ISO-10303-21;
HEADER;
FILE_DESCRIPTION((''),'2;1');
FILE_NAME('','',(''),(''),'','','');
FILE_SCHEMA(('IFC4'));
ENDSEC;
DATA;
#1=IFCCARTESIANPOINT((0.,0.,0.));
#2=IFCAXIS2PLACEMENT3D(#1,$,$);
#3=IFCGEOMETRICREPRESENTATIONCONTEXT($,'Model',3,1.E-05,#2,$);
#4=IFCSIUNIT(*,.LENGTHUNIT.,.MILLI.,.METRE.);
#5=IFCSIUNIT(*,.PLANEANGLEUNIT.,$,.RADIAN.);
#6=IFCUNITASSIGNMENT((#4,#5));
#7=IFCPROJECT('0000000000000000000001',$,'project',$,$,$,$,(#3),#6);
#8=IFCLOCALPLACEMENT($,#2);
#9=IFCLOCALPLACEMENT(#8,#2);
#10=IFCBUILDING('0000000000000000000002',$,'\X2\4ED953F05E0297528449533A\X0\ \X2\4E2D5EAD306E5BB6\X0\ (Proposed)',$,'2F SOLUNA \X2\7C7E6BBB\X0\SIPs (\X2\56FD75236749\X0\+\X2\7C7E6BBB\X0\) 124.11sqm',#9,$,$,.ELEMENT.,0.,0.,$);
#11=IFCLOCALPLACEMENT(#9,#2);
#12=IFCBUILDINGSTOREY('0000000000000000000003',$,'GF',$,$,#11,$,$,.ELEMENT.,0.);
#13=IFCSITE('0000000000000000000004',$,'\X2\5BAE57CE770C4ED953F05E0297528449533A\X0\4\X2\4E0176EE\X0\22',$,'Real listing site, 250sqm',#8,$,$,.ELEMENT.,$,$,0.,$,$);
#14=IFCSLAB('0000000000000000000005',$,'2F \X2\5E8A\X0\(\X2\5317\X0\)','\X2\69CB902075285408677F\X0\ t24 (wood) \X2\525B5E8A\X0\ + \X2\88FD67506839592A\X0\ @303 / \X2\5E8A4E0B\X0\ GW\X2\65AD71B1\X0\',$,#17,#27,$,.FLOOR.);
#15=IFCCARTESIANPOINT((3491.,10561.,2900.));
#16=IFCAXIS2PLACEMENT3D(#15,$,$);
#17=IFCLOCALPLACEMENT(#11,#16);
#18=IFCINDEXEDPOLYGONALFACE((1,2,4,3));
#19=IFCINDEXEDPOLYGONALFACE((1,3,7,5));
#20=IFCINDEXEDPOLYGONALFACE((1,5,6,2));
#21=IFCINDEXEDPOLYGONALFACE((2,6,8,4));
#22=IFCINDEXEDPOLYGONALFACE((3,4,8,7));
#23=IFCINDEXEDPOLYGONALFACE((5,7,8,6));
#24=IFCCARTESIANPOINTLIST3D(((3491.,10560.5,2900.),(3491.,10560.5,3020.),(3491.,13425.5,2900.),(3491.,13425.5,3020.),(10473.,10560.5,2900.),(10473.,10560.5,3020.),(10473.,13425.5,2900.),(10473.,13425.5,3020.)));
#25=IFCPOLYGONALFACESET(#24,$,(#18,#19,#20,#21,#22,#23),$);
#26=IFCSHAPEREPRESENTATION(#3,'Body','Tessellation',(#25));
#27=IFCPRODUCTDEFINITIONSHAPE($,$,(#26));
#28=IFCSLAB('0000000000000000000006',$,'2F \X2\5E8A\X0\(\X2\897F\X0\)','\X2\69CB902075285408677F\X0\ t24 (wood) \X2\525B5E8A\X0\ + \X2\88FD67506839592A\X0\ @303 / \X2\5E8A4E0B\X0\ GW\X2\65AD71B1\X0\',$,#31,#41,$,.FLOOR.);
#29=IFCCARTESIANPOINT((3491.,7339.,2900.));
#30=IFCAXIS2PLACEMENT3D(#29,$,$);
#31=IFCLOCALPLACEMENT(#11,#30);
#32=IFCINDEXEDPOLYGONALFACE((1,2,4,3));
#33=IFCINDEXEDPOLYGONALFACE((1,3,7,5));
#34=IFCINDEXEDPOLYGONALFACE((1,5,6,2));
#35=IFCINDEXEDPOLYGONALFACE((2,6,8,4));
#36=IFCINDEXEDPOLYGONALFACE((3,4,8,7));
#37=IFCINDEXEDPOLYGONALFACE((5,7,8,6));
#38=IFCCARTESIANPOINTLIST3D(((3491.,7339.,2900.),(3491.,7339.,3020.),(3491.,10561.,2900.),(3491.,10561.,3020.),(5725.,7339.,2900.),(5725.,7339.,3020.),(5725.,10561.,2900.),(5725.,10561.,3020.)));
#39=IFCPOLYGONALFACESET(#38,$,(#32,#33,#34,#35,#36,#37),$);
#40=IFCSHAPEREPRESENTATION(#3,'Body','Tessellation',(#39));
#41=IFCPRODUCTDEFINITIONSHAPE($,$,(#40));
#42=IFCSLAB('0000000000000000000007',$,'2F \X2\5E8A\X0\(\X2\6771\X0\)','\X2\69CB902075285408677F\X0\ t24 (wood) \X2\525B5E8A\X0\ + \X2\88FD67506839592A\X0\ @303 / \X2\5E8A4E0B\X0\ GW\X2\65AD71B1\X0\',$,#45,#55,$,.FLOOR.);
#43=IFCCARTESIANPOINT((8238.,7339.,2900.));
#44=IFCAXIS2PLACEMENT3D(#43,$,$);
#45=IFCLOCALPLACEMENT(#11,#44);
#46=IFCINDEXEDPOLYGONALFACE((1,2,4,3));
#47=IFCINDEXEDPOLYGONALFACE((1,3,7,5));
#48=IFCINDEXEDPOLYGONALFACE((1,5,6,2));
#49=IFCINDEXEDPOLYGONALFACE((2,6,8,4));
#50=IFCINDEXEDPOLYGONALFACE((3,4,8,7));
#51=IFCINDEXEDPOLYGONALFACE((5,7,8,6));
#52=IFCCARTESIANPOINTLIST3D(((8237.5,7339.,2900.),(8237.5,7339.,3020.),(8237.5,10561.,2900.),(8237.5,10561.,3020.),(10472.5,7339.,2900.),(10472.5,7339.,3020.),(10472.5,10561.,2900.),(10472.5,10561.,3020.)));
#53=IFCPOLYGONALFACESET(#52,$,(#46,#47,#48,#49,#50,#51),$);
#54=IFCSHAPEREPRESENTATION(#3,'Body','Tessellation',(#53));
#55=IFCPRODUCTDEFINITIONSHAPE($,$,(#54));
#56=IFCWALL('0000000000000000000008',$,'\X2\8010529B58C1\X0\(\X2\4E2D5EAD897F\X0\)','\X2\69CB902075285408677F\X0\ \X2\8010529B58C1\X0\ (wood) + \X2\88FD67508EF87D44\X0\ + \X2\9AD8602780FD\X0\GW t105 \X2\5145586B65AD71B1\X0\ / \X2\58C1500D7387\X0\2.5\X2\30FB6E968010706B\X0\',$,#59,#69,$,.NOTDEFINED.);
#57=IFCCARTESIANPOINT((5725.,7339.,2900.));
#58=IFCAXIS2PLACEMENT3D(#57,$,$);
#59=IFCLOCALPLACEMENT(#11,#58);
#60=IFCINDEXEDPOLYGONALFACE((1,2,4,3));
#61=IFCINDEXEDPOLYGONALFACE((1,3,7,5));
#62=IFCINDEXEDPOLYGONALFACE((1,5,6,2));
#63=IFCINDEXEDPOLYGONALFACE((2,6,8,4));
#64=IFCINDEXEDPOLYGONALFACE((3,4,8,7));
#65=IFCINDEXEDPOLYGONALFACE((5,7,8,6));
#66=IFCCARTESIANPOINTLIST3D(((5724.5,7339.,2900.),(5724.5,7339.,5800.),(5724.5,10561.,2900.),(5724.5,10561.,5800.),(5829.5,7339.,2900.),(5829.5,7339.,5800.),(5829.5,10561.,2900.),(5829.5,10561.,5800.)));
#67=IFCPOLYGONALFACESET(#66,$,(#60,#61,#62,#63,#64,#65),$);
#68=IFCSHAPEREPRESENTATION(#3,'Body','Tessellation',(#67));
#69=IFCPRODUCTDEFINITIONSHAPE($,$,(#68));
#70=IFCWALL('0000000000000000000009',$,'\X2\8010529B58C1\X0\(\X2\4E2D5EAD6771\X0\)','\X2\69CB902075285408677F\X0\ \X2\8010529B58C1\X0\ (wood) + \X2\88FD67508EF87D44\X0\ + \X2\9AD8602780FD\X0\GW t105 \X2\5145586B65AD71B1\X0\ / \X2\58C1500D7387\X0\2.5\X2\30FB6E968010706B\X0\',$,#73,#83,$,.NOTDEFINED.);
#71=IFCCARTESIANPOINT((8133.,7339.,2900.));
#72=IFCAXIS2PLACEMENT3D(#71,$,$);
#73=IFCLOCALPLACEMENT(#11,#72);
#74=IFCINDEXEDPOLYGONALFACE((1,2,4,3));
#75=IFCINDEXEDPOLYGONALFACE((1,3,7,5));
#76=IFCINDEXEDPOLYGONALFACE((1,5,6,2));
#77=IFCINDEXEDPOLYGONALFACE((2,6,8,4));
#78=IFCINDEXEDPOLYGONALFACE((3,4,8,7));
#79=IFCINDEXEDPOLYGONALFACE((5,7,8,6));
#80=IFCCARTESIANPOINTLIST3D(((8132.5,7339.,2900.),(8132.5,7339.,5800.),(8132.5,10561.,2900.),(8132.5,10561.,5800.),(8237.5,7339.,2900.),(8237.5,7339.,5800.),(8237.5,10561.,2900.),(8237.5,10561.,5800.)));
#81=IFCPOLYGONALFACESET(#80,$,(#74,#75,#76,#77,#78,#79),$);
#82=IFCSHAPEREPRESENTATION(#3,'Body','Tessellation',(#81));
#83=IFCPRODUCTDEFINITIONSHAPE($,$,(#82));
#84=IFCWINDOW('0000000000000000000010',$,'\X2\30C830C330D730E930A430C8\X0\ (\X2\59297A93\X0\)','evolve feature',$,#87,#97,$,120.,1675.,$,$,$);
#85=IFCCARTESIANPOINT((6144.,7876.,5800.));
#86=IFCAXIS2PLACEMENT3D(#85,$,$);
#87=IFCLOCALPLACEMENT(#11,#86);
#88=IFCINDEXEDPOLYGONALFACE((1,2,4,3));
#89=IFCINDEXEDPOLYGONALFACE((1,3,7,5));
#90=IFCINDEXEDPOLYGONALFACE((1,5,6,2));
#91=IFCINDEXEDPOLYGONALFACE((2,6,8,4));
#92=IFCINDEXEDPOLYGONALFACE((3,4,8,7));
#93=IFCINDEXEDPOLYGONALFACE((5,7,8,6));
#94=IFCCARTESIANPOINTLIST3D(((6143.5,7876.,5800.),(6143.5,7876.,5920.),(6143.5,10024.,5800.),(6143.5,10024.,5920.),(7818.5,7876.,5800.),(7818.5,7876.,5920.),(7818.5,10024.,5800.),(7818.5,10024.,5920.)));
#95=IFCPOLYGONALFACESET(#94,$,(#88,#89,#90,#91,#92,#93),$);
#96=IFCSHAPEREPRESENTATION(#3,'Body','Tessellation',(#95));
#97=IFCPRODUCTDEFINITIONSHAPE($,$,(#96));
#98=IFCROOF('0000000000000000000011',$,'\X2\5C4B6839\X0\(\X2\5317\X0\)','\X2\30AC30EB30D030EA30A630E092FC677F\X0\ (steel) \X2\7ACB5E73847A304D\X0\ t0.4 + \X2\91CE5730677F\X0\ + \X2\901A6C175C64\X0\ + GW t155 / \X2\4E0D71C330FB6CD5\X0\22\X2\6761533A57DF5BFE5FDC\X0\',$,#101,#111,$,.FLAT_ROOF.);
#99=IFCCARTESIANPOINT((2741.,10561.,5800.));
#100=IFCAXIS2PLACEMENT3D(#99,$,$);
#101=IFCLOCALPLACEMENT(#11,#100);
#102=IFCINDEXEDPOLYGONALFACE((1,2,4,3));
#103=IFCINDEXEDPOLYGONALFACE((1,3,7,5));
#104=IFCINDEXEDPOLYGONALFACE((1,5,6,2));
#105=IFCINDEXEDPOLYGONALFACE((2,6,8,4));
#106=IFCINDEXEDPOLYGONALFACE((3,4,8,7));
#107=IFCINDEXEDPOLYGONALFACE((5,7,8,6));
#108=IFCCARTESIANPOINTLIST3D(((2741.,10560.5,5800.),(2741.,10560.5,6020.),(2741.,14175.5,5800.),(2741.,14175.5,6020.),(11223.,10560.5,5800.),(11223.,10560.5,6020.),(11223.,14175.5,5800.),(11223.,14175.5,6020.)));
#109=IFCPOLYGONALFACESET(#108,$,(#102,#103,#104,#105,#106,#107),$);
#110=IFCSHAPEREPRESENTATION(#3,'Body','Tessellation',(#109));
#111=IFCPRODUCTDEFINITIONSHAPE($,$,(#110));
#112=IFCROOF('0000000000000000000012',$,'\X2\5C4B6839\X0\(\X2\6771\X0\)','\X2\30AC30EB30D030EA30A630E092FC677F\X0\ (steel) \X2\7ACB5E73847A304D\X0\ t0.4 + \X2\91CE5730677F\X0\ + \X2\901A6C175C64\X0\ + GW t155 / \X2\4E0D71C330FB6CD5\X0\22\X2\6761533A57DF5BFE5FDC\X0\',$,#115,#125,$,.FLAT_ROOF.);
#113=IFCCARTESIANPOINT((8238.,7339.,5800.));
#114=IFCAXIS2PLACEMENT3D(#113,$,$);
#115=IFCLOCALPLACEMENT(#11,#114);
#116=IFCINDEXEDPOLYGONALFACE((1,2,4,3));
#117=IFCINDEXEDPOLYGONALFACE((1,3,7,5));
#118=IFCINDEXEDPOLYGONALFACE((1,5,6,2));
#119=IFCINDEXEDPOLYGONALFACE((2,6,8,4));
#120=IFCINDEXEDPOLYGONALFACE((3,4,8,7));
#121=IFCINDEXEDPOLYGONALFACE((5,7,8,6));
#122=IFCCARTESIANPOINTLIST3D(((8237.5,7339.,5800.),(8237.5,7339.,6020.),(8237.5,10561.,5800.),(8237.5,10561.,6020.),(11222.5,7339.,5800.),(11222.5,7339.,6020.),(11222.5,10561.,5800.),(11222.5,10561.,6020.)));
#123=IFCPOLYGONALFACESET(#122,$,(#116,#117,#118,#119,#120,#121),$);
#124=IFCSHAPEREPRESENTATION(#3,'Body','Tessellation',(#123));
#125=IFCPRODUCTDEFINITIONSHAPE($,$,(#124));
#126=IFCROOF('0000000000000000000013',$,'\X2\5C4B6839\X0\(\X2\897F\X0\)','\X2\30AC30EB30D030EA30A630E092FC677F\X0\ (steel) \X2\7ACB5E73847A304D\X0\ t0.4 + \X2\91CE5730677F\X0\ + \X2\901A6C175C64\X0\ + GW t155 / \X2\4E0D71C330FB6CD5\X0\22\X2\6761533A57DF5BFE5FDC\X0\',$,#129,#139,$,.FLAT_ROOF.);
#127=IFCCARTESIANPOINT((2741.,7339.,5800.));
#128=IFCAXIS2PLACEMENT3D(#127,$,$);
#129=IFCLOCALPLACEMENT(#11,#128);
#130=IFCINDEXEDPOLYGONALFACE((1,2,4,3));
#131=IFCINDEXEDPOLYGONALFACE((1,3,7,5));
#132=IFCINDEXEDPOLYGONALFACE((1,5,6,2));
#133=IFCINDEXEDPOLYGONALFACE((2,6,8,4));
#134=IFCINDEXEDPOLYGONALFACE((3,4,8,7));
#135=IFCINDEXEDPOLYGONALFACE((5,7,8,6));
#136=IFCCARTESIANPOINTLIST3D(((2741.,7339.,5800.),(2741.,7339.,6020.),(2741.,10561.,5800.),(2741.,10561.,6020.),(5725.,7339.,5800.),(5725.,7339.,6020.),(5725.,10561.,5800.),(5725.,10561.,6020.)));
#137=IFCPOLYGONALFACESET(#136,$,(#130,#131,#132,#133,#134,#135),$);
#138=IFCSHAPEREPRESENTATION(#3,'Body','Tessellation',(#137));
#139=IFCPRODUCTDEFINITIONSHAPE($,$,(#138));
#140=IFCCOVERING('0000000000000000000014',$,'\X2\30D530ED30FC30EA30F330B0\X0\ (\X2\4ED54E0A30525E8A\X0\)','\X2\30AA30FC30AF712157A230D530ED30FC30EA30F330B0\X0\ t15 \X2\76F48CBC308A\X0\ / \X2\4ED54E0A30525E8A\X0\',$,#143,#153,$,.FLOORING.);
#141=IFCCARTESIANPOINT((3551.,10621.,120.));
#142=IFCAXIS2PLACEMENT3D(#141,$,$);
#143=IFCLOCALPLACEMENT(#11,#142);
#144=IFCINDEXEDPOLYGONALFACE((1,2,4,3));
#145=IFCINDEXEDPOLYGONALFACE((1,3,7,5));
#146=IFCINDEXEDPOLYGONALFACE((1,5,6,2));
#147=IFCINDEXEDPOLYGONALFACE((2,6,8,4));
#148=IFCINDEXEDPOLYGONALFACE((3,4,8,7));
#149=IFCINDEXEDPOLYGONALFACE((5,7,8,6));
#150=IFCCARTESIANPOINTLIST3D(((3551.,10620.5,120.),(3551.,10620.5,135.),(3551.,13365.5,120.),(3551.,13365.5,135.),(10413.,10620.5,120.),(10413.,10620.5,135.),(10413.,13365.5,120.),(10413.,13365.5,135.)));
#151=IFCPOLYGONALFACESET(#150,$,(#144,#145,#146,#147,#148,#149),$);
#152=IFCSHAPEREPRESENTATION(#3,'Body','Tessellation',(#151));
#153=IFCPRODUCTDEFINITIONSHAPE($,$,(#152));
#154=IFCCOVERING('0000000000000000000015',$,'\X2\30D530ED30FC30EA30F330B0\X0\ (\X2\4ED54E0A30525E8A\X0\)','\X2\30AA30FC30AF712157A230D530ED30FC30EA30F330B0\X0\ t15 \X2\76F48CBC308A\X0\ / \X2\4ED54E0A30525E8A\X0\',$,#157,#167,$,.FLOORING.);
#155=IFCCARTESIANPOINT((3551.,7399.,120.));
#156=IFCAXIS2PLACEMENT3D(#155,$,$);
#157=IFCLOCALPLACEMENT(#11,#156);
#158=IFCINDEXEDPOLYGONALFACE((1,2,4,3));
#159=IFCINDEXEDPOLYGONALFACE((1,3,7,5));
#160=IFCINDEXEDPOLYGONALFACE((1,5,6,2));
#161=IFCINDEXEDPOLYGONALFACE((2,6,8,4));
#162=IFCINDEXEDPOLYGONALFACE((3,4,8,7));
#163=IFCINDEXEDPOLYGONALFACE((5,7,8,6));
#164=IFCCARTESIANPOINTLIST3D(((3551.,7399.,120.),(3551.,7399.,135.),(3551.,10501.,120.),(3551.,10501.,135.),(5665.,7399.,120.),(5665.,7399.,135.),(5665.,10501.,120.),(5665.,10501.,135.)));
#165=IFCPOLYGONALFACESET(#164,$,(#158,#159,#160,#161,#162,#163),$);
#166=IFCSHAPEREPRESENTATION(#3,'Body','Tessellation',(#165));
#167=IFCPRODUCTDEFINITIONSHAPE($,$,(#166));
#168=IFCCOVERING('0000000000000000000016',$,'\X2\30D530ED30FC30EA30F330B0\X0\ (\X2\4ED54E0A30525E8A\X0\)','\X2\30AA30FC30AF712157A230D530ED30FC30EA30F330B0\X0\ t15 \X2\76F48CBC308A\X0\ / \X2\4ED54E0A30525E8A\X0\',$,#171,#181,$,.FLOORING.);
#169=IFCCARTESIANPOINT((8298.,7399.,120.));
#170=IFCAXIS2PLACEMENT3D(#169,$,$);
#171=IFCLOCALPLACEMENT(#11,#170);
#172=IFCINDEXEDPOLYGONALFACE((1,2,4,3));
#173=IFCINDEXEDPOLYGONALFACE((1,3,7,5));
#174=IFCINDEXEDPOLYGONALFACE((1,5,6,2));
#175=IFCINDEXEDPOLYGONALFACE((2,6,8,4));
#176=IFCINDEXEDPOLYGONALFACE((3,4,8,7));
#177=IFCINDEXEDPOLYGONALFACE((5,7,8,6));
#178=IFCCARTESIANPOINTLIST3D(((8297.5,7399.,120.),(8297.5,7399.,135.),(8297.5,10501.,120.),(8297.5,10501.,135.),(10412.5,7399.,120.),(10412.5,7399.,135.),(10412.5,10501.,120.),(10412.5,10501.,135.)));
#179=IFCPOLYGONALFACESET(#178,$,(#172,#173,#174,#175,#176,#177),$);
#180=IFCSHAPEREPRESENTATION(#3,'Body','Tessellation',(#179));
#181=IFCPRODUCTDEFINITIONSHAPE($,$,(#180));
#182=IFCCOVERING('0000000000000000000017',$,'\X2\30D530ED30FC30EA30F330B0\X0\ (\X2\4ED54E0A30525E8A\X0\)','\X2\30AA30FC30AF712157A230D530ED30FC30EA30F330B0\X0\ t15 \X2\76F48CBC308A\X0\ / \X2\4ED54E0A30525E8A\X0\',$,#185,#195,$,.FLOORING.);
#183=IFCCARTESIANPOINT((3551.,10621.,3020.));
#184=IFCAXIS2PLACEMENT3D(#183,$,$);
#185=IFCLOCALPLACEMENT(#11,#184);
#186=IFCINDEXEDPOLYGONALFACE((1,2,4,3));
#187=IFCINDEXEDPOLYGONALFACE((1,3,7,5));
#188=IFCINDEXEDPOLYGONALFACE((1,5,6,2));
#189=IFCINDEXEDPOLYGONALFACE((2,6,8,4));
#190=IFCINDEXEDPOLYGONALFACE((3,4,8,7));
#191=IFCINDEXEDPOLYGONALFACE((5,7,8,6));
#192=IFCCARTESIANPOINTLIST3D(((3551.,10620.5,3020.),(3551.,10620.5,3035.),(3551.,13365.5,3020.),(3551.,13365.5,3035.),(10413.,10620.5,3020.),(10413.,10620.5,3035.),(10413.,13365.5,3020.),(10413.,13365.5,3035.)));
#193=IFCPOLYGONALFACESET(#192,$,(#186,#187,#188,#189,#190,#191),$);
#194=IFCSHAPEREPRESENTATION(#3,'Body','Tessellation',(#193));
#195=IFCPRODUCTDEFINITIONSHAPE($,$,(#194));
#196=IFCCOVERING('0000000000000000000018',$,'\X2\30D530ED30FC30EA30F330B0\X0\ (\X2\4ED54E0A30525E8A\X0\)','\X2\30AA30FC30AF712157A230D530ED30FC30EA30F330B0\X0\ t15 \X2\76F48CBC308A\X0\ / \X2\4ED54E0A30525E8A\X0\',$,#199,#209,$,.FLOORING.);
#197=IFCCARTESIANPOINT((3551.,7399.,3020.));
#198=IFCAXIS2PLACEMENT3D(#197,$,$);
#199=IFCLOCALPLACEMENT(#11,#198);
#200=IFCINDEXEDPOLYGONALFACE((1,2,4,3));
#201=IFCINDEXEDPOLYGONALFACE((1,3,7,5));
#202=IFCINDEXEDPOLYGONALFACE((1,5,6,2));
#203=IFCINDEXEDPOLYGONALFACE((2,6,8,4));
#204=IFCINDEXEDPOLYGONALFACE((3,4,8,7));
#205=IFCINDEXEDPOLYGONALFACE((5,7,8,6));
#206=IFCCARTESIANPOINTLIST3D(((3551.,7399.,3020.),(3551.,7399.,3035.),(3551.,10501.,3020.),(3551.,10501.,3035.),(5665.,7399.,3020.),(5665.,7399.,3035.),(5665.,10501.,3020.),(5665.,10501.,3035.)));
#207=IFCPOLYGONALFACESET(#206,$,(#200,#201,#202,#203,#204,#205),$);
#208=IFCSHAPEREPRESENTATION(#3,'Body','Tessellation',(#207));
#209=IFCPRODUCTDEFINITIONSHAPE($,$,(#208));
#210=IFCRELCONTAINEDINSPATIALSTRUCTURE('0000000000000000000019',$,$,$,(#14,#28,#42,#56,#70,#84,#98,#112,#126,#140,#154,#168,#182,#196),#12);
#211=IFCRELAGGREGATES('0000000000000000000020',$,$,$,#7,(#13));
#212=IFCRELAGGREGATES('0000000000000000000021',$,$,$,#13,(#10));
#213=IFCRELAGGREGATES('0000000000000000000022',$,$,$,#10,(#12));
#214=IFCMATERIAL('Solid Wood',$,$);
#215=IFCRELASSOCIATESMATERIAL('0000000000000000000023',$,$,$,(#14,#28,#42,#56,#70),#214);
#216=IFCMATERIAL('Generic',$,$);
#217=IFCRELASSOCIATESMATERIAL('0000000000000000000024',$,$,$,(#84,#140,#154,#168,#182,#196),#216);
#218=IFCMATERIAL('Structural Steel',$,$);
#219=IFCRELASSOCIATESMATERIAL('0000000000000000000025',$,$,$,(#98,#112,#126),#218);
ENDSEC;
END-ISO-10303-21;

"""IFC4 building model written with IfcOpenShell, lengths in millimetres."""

from ifc_helpers import new_model, si_unit, frame, frame_2d, origin, place, context, project, spatial, rectangle, extrude, material, element, save


model = new_model("IFC4")

# Units and contexts
model_context = context("Model", 3, precision=1e-05, world=origin())
ifc_project = project(units=[si_unit("LENGTHUNIT", "METRE", prefix="MILLI"), si_unit("PLANEANGLEUNIT", "RADIAN")], contexts=[model_context])

# Site, building, storey
site_placement = place(None, origin())
site = spatial("IfcSite", under=ifc_project, at=site_placement, Name="宮城県仙台市青葉区4丁目22", ObjectType="Real listing site, 250sqm", CompositionType="ELEMENT", RefElevation=0.0)
building_placement = place(site_placement, origin())
building = spatial("IfcBuilding", under=site, at=building_placement, Name="仙台市青葉区 中庭の家 (Proposed)", ObjectType="2F SOLUNA 籾殻SIPs (国産杉+籾殻) 124.11sqm", CompositionType="ELEMENT", ElevationOfRefHeight=0.0, ElevationOfTerrain=0.0)
storey_placement = place(building_placement, origin())
storey = spatial("IfcBuildingStorey", under=building, at=storey_placement, Name="GF", CompositionType="ELEMENT", Elevation=0.0)

# Slabs
ifc_material_1 = material(Name="Solid Wood")
slab_1_placement = place(storey_placement, frame((3491.0, 10561.0, 2900.0)))
element("IfcSlab", 1, at=slab_1_placement, inside=storey, material=ifc_material_1, Name="2F 床(北)", Description="構造用合板 t24 (wood) 剛床 + 製材根太 @303 / 床下 GW断熱", PredefinedType="FLOOR", context=model_context, shape_type="SweptSolid", body=[
    extrude(rectangle(XDim=6982.0, YDim=2865.0, at=frame_2d((3491.0, 1432.0))), frame((3491.0, 10561.0, 2900.0)), (0.0, 0.0, 1.0), 120.0),
])
slab_2_placement = place(storey_placement, frame((3491.0, 7339.0, 2900.0)))
element("IfcSlab", 2, at=slab_2_placement, inside=storey, material=ifc_material_1, Name="2F 床(西)", Description="構造用合板 t24 (wood) 剛床 + 製材根太 @303 / 床下 GW断熱", PredefinedType="FLOOR", context=model_context, shape_type="SweptSolid", body=[
    extrude(rectangle(XDim=2234.0, YDim=3222.0, at=frame_2d((1117.0, 1611.0))), frame((3491.0, 7339.0, 2900.0)), (0.0, 0.0, 1.0), 120.0),
])
slab_3_placement = place(storey_placement, frame((8238.0, 7339.0, 2900.0)))
element("IfcSlab", 3, at=slab_3_placement, inside=storey, material=ifc_material_1, Name="2F 床(東)", Description="構造用合板 t24 (wood) 剛床 + 製材根太 @303 / 床下 GW断熱", PredefinedType="FLOOR", context=model_context, shape_type="SweptSolid", body=[
    extrude(rectangle(XDim=2235.0, YDim=3222.0, at=frame_2d((1117.0, 1611.0))), frame((8238.0, 7339.0, 2900.0)), (0.0, 0.0, 1.0), 120.0),
])

# Walls
wall_1_placement = place(storey_placement, frame((5725.0, 7339.0, 2900.0)))
element("IfcWall", 4, at=wall_1_placement, inside=storey, material=ifc_material_1, Name="耐力壁(中庭西)", Description="構造用合板 耐力壁 (wood) + 製材軸組 + 高性能GW t105 充填断熱 / 壁倍率2.5・準耐火", PredefinedType="NOTDEFINED", context=model_context, shape_type="SweptSolid", body=[
    extrude(rectangle(XDim=105.0, YDim=3222.0, at=frame_2d((52.0, 1611.0))), frame((5725.0, 7339.0, 2900.0)), (0.0, 0.0, 1.0), 2900.0),
])
wall_2_placement = place(storey_placement, frame((8133.0, 7339.0, 2900.0)))
element("IfcWall", 5, at=wall_2_placement, inside=storey, material=ifc_material_1, Name="耐力壁(中庭東)", Description="構造用合板 耐力壁 (wood) + 製材軸組 + 高性能GW t105 充填断熱 / 壁倍率2.5・準耐火", PredefinedType="NOTDEFINED", context=model_context, shape_type="SweptSolid", body=[
    extrude(rectangle(XDim=105.0, YDim=3222.0, at=frame_2d((52.0, 1611.0))), frame((8133.0, 7339.0, 2900.0)), (0.0, 0.0, 1.0), 2900.0),
])

# Window
ifc_material_2 = material(Name="Generic")
window_1_placement = place(storey_placement, frame((6144.0, 7876.0, 5800.0)))
element("IfcWindow", 6, at=window_1_placement, inside=storey, material=ifc_material_2, Name="トップライト (天窓)", Description="evolve feature", OverallHeight=120.0, OverallWidth=1675.0, context=model_context, shape_type="SweptSolid", body=[
    extrude(rectangle(XDim=1675.0, YDim=2148.0, at=frame_2d((837.0, 1074.0))), frame((6144.0, 7876.0, 5800.0)), (0.0, 0.0, 1.0), 120.0),
])

# Roofs
ifc_material_3 = material(Name="Structural Steel")
roof_1_placement = place(storey_placement, frame((2741.0, 10561.0, 5800.0)))
element("IfcRoof", 7, at=roof_1_placement, inside=storey, material=ifc_material_3, Name="屋根(北)", Description="ガルバリウム鋼板 (steel) 立平葺き t0.4 + 野地板 + 通気層 + GW t155 / 不燃・法22条区域対応", PredefinedType="FLAT_ROOF", context=model_context, shape_type="SweptSolid", body=[
    extrude(rectangle(XDim=8482.0, YDim=3615.0, at=frame_2d((4241.0, 1807.0))), frame((2741.0, 10561.0, 5800.0)), (0.0, 0.0, 1.0), 220.0),
])
roof_2_placement = place(storey_placement, frame((8238.0, 7339.0, 5800.0)))
element("IfcRoof", 8, at=roof_2_placement, inside=storey, material=ifc_material_3, Name="屋根(東)", Description="ガルバリウム鋼板 (steel) 立平葺き t0.4 + 野地板 + 通気層 + GW t155 / 不燃・法22条区域対応", PredefinedType="FLAT_ROOF", context=model_context, shape_type="SweptSolid", body=[
    extrude(rectangle(XDim=2985.0, YDim=3222.0, at=frame_2d((1492.0, 1611.0))), frame((8238.0, 7339.0, 5800.0)), (0.0, 0.0, 1.0), 220.0),
])
roof_3_placement = place(storey_placement, frame((2741.0, 7339.0, 5800.0)))
element("IfcRoof", 9, at=roof_3_placement, inside=storey, material=ifc_material_3, Name="屋根(西)", Description="ガルバリウム鋼板 (steel) 立平葺き t0.4 + 野地板 + 通気層 + GW t155 / 不燃・法22条区域対応", PredefinedType="FLAT_ROOF", context=model_context, shape_type="SweptSolid", body=[
    extrude(rectangle(XDim=2984.0, YDim=3222.0, at=frame_2d((1492.0, 1611.0))), frame((2741.0, 7339.0, 5800.0)), (0.0, 0.0, 1.0), 220.0),
])

# Coverings
covering_1_placement = place(storey_placement, frame((3551.0, 10621.0, 120.0)))
element("IfcCovering", 10, at=covering_1_placement, inside=storey, material=ifc_material_2, Name="フローリング (仕上げ床)", Description="オーク無垢フローリング t15 直貼り / 仕上げ床", PredefinedType="FLOORING", context=model_context, shape_type="SweptSolid", body=[
    extrude(rectangle(XDim=6862.0, YDim=2745.0, at=frame_2d((3431.0, 1372.0))), frame((3551.0, 10621.0, 120.0)), (0.0, 0.0, 1.0), 15.0),
])
covering_2_placement = place(storey_placement, frame((3551.0, 7399.0, 120.0)))
element("IfcCovering", 11, at=covering_2_placement, inside=storey, material=ifc_material_2, Name="フローリング (仕上げ床)", Description="オーク無垢フローリング t15 直貼り / 仕上げ床", PredefinedType="FLOORING", context=model_context, shape_type="SweptSolid", body=[
    extrude(rectangle(XDim=2114.0, YDim=3102.0, at=frame_2d((1057.0, 1551.0))), frame((3551.0, 7399.0, 120.0)), (0.0, 0.0, 1.0), 15.0),
])
covering_3_placement = place(storey_placement, frame((8298.0, 7399.0, 120.0)))
element("IfcCovering", 12, at=covering_3_placement, inside=storey, material=ifc_material_2, Name="フローリング (仕上げ床)", Description="オーク無垢フローリング t15 直貼り / 仕上げ床", PredefinedType="FLOORING", context=model_context, shape_type="SweptSolid", body=[
    extrude(rectangle(XDim=2115.0, YDim=3102.0, at=frame_2d((1057.0, 1551.0))), frame((8298.0, 7399.0, 120.0)), (0.0, 0.0, 1.0), 15.0),
])
covering_4_placement = place(storey_placement, frame((3551.0, 10621.0, 3020.0)))
element("IfcCovering", 13, at=covering_4_placement, inside=storey, material=ifc_material_2, Name="フローリング (仕上げ床)", Description="オーク無垢フローリング t15 直貼り / 仕上げ床", PredefinedType="FLOORING", context=model_context, shape_type="SweptSolid", body=[
    extrude(rectangle(XDim=6862.0, YDim=2745.0, at=frame_2d((3431.0, 1372.0))), frame((3551.0, 10621.0, 3020.0)), (0.0, 0.0, 1.0), 15.0),
])
covering_5_placement = place(storey_placement, frame((3551.0, 7399.0, 3020.0)))
element("IfcCovering", 14, at=covering_5_placement, inside=storey, material=ifc_material_2, Name="フローリング (仕上げ床)", Description="オーク無垢フローリング t15 直貼り / 仕上げ床", PredefinedType="FLOORING", context=model_context, shape_type="SweptSolid", body=[
    extrude(rectangle(XDim=2114.0, YDim=3102.0, at=frame_2d((1057.0, 1551.0))), frame((3551.0, 7399.0, 3020.0)), (0.0, 0.0, 1.0), 15.0),
])

save(model, "model.ifc")
